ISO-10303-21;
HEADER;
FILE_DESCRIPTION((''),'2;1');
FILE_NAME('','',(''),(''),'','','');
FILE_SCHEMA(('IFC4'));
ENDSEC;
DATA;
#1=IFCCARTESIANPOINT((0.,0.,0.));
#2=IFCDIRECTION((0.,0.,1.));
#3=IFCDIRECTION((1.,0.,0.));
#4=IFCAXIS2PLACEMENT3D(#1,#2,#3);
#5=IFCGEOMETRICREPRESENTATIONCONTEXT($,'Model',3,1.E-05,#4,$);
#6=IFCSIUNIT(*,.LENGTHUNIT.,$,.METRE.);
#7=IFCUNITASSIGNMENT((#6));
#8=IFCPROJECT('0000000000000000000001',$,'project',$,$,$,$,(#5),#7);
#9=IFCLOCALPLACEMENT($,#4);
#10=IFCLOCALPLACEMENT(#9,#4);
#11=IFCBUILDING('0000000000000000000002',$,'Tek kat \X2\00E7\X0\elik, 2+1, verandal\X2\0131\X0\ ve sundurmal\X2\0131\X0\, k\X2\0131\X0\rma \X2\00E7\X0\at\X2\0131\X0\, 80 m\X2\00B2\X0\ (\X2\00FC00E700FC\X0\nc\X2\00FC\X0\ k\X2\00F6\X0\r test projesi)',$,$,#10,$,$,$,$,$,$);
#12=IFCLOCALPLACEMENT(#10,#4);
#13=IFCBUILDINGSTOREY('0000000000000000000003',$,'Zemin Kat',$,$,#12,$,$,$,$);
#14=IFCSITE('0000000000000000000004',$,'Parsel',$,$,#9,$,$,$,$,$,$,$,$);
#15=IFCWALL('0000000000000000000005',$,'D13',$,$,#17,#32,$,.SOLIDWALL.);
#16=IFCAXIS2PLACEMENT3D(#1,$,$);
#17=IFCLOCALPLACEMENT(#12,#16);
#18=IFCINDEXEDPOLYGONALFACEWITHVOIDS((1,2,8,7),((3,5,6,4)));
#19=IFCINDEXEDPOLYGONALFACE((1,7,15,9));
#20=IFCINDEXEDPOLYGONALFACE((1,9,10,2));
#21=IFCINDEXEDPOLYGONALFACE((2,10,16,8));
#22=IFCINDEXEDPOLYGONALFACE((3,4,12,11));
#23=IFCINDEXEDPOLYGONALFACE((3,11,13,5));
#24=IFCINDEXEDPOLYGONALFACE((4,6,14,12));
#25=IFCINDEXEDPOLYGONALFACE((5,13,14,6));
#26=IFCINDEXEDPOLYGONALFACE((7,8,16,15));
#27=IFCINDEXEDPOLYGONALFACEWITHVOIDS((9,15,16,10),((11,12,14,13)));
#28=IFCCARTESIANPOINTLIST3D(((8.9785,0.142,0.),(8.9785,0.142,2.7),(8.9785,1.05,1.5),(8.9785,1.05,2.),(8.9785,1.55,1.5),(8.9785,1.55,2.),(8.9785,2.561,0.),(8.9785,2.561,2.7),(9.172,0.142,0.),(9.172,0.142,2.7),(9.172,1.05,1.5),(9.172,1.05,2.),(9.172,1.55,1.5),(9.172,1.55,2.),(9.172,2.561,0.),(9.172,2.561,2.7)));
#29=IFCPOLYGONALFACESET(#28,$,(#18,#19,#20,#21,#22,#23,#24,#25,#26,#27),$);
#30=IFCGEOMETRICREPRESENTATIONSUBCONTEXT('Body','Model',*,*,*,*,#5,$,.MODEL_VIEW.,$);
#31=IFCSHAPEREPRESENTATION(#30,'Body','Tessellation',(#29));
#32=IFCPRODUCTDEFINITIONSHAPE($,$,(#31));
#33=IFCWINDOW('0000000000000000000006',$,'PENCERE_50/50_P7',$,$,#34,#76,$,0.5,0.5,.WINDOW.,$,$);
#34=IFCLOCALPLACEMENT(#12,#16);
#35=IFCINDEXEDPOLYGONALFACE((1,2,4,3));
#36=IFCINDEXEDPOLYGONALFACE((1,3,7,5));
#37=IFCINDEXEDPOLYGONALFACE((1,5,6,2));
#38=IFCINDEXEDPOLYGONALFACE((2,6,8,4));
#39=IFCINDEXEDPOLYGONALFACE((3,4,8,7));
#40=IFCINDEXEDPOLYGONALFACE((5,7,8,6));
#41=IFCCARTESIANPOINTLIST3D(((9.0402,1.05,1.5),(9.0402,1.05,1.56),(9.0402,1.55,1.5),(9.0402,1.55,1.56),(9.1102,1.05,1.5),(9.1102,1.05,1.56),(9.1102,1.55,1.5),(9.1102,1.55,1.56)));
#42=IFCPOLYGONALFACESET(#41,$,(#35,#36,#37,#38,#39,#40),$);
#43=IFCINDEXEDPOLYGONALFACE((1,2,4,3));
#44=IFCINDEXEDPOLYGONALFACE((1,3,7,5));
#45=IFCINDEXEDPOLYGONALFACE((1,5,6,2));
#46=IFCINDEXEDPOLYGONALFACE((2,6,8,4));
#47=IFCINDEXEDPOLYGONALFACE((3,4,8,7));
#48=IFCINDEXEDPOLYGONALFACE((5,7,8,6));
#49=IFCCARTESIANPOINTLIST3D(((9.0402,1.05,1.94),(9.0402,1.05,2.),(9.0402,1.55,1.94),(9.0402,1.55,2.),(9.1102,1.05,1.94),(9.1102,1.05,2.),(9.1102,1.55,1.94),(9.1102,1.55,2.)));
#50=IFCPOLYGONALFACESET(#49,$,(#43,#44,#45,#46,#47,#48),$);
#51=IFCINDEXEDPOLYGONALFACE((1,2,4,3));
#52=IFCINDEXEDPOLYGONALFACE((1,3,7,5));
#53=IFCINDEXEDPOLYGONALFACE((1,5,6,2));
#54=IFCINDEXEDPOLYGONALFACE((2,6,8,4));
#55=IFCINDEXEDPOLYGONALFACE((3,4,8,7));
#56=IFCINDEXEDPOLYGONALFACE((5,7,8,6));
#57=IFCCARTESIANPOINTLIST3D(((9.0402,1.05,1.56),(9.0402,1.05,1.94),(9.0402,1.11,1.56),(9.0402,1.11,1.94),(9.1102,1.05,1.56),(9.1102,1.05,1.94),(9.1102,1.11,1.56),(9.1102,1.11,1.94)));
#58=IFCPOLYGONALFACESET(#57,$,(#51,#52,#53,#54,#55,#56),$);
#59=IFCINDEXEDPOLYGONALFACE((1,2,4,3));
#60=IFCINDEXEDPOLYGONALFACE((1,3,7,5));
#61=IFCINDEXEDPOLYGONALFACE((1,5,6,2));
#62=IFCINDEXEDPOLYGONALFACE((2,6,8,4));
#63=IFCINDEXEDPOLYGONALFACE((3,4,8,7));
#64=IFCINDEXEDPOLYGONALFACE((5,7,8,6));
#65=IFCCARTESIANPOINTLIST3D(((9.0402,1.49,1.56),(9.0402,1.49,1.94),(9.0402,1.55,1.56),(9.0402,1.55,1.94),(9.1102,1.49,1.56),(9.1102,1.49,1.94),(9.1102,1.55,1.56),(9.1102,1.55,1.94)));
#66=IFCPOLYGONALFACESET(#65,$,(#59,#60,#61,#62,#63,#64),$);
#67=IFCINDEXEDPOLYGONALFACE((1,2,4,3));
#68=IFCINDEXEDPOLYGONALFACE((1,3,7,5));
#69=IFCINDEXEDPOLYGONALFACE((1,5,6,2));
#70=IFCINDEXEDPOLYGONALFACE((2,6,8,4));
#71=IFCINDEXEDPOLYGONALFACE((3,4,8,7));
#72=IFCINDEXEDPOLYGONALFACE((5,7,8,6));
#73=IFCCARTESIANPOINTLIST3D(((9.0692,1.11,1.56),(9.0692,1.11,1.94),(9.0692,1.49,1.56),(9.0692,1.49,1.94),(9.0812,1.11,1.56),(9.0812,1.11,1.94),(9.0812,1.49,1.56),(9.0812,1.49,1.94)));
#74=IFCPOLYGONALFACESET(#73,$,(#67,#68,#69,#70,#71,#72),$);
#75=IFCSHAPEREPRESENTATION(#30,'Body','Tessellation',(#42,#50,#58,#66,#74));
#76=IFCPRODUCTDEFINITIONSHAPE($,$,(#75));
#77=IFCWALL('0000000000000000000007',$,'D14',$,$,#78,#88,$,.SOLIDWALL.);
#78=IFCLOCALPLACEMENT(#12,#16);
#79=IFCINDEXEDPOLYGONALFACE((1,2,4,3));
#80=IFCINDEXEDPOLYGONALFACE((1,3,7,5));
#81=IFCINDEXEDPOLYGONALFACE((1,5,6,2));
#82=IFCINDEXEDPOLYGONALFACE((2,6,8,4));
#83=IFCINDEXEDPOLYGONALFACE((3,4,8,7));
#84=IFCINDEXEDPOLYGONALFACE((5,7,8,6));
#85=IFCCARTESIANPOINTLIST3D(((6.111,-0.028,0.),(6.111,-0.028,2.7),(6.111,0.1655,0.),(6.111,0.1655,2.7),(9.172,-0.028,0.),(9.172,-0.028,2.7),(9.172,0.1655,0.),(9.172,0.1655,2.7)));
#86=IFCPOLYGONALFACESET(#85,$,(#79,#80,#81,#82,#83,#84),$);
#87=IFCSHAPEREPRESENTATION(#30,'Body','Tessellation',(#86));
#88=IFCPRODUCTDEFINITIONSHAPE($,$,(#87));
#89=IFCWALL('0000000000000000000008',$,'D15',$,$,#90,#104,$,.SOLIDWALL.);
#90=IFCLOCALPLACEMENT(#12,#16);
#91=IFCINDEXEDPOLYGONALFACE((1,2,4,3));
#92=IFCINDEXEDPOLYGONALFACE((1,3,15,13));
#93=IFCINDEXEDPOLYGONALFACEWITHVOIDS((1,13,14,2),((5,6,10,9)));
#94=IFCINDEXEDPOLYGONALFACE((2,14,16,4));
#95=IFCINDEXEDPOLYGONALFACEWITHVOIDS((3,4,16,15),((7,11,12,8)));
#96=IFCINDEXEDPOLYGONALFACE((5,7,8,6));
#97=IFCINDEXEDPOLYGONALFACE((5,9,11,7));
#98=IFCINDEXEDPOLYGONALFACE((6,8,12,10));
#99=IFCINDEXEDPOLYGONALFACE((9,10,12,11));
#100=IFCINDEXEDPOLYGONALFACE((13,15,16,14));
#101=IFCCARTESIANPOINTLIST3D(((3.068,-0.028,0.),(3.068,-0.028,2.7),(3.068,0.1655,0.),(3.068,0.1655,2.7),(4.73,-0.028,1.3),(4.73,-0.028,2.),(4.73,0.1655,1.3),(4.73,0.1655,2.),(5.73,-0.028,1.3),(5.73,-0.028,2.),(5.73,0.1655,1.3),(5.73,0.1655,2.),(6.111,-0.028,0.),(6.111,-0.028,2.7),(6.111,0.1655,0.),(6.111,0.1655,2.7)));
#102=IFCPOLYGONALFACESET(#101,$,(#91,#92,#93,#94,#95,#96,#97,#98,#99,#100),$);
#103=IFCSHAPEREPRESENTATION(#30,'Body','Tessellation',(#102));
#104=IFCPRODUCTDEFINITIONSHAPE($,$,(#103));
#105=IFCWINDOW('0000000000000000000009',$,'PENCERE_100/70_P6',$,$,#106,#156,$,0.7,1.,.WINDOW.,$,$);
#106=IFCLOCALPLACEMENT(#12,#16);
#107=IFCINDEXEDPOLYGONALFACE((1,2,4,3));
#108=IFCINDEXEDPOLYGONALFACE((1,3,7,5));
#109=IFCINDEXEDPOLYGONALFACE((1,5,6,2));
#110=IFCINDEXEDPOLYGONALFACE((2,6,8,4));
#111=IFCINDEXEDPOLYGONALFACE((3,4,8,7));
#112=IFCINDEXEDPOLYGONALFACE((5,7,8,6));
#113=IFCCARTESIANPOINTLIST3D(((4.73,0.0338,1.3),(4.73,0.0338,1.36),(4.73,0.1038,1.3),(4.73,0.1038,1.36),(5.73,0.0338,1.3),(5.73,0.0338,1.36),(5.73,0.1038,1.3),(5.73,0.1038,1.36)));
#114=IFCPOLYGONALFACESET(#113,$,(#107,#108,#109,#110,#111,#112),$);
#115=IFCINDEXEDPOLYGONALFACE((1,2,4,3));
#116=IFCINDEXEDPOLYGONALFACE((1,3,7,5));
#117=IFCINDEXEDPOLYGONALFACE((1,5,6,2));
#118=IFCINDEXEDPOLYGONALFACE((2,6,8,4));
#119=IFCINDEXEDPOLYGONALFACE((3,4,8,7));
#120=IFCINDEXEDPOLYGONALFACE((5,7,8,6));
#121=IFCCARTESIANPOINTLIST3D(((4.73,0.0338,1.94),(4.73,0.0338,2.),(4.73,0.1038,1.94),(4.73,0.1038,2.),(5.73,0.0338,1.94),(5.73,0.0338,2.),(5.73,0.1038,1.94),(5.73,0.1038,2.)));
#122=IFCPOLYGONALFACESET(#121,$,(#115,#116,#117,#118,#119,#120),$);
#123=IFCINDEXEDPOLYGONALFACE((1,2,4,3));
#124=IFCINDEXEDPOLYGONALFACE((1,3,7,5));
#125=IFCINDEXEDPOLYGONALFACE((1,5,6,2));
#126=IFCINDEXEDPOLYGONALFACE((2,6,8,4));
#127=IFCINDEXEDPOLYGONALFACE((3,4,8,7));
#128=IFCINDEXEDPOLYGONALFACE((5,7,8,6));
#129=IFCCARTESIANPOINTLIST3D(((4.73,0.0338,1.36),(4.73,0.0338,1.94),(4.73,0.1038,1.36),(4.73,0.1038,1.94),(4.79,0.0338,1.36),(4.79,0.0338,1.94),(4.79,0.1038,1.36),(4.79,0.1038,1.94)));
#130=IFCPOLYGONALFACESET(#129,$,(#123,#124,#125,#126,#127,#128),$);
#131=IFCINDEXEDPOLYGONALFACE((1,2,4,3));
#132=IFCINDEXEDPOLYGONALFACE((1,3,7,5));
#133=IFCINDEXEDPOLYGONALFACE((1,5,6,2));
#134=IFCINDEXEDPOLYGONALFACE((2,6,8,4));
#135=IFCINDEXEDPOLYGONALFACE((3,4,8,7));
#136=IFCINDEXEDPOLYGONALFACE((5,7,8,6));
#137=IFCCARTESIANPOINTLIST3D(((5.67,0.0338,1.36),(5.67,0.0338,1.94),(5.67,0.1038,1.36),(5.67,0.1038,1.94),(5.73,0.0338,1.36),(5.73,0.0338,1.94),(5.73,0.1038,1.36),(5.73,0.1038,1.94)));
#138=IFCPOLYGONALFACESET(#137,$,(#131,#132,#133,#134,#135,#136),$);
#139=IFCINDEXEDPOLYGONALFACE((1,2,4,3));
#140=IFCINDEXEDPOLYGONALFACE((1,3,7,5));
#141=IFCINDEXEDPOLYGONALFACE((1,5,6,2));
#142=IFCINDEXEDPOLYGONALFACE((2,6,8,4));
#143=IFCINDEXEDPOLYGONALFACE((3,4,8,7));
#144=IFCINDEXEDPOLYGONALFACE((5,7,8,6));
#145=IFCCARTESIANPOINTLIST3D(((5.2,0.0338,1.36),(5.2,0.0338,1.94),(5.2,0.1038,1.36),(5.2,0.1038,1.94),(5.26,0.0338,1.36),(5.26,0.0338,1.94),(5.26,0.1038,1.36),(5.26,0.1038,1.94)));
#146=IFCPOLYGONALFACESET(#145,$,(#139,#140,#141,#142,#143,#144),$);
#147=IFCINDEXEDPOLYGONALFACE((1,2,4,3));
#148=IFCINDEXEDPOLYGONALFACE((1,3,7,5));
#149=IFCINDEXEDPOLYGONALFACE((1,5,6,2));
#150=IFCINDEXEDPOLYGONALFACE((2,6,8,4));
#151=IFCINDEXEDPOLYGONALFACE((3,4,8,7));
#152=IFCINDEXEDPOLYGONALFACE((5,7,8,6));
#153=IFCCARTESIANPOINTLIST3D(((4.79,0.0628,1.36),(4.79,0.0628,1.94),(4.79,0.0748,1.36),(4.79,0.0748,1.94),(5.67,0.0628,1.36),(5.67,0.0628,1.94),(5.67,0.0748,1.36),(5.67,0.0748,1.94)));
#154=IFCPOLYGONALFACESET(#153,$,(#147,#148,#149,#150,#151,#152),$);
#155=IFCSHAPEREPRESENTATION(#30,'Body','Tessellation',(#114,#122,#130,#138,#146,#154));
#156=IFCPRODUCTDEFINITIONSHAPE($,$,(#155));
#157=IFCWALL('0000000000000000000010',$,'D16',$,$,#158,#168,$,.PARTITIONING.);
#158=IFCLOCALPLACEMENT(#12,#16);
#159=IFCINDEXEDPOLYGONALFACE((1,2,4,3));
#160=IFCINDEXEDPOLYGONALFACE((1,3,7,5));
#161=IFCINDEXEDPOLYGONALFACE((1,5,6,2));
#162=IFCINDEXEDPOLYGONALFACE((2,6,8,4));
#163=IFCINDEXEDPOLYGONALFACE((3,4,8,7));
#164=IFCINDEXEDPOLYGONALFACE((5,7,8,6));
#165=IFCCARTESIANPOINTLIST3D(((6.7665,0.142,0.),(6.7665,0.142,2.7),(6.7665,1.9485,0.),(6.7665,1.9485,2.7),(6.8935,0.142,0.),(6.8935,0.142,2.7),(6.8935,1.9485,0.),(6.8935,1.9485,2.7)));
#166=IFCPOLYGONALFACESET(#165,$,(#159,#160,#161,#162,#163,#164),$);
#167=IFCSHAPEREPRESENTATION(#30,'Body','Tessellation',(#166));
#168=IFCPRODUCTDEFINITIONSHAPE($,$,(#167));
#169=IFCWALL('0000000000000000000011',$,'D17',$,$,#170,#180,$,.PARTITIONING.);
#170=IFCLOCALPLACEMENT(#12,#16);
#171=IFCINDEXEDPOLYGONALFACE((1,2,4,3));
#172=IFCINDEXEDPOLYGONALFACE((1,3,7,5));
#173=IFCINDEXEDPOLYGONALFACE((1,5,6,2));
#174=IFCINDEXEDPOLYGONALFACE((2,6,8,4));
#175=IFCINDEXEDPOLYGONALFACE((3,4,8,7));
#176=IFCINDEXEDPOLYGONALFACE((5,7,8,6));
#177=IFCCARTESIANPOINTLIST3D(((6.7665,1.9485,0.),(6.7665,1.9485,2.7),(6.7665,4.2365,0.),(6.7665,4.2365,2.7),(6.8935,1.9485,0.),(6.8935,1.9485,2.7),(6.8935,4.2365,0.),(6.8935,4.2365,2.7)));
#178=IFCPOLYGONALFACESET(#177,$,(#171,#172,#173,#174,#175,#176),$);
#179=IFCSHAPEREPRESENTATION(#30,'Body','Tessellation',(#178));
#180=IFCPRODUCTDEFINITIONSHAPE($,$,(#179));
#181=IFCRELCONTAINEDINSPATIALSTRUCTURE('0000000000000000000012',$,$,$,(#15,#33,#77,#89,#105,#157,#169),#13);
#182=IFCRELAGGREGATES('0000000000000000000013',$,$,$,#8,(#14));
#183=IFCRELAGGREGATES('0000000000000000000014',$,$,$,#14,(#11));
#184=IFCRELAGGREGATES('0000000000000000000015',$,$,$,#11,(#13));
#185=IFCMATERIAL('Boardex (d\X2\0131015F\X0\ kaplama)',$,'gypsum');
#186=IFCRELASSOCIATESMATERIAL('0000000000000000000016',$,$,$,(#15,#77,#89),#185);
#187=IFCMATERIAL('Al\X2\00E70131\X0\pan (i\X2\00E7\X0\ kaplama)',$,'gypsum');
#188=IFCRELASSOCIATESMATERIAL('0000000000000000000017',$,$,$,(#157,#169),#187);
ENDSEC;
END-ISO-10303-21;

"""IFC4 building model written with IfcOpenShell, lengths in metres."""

from ifc_helpers import new_model, si_unit, frame, origin_with_axes, place, context, subcontext, project, spatial, line, indexed_curve, outline, extrude, material, element, fill, save


model = new_model("IFC4")

# Units and contexts
model_context = context("Model", 3, precision=1e-05, world=origin_with_axes())
body_context = subcontext(model_context, "Body", "Model", "MODEL_VIEW")
ifc_project = project(units=[si_unit("LENGTHUNIT", "METRE")], contexts=[model_context])

# Site, building, storey
site_placement = place(None, origin_with_axes())
site = spatial("IfcSite", under=ifc_project, at=site_placement, Name="Parsel")
building_placement = place(site_placement, origin_with_axes())
building = spatial("IfcBuilding", under=site, at=building_placement, Name="Tek kat çelik, 2+1, verandalı ve sundurmalı, kırma çatı, 80 m² (üçüncü kör test projesi)")
storey_placement = place(building_placement, origin_with_axes())
storey = spatial("IfcBuildingStorey", under=building, at=storey_placement, Name="Zemin Kat")

# Shared definitions
ifc_material_1 = material(Name="Boardex (dış kaplama)", Category="gypsum")

# Wall, opening, window
wall_1_placement = place(storey_placement, origin_with_axes())
wall_1 = element("IfcWall", 1, at=wall_1_placement, inside=storey, material=ifc_material_1, Name="D13", PredefinedType="SOLIDWALL", context=body_context, shape_type="SweptSolid", body=[
    extrude(outline(indexed_curve([(0.0, 0.0), (0.1935, 0.0), (0.1935, 2.419), (0.0, 2.419)], segments=[line(1, 2, 3, 4, 1)])), frame((8.9785, 0.142, 0.0), z_axis=(0.0, 0.0, 1.0), x_axis=(1.0, 0.0, 0.0)), (0.0, 0.0, 1.0), 2.7),
])
opening_1_placement = place(wall_1_placement, origin_with_axes())
opening_1 = element("IfcOpeningElement", 2, at=opening_1_placement, cuts=wall_1, PredefinedType="OPENING", context=body_context, shape_type="SweptSolid", body=[
    extrude(outline(indexed_curve([(0.0, 0.0), (0.2335, 0.0), (0.2335, 0.5), (0.0, 0.5)], segments=[line(1, 2, 3, 4, 1)])), frame((8.9585, 1.05, 1.5), z_axis=(0.0, 0.0, 1.0), x_axis=(1.0, 0.0, 0.0)), (0.0, 0.0, 1.0), 0.5),
])
window_1_placement = place(storey_placement, origin_with_axes())
window_1 = element("IfcWindow", 3, at=window_1_placement, inside=storey, Name="PENCERE_50/50_P7", OverallHeight=0.5, OverallWidth=0.5, PredefinedType="WINDOW", context=body_context, shape_type="SweptSolid", body=[
    extrude(outline(indexed_curve([(0.0, 0.0), (0.07, 0.0), (0.07, 0.5), (0.0, 0.5)], segments=[line(1, 2, 3, 4, 1)])), frame((9.0403, 1.05, 1.5), z_axis=(0.0, 0.0, 1.0), x_axis=(1.0, 0.0, 0.0)), (0.0, 0.0, 1.0), 0.06),
    extrude(outline(indexed_curve([(0.0, 0.0), (0.07, 0.0), (0.07, 0.5), (0.0, 0.5)], segments=[line(1, 2, 3, 4, 1)])), frame((9.0403, 1.05, 1.94), z_axis=(0.0, 0.0, 1.0), x_axis=(1.0, 0.0, 0.0)), (0.0, 0.0, 1.0), 0.06),
    extrude(outline(indexed_curve([(0.0, 0.0), (0.07, 0.0), (0.07, 0.06), (0.0, 0.06)], segments=[line(1, 2, 3, 4, 1)])), frame((9.0403, 1.05, 1.56), z_axis=(0.0, 0.0, 1.0), x_axis=(1.0, 0.0, 0.0)), (0.0, 0.0, 1.0), 0.38),
    extrude(outline(indexed_curve([(0.0, 0.0), (0.07, 0.0), (0.07, 0.06), (0.0, 0.06)], segments=[line(1, 2, 3, 4, 1)])), frame((9.0403, 1.49, 1.56), z_axis=(0.0, 0.0, 1.0), x_axis=(1.0, 0.0, 0.0)), (0.0, 0.0, 1.0), 0.38),
    extrude(outline(indexed_curve([(0.0, 0.0), (0.012, 0.0), (0.012, 0.38), (0.0, 0.38)], segments=[line(1, 2, 3, 4, 1)])), frame((9.0693, 1.11, 1.56), z_axis=(0.0, 0.0, 1.0), x_axis=(1.0, 0.0, 0.0)), (0.0, 0.0, 1.0), 0.38),
])
fill(opening_1, window_1)

# Wall
wall_2_placement = place(storey_placement, origin_with_axes())
element("IfcWall", 4, at=wall_2_placement, inside=storey, material=ifc_material_1, Name="D14", PredefinedType="SOLIDWALL", context=body_context, shape_type="SweptSolid", body=[
    extrude(outline(indexed_curve([(0.0, 0.0), (3.061, 0.0), (3.061, 0.1935), (0.0, 0.1935)], segments=[line(1, 2, 3, 4, 1)])), frame((6.111, -0.028, 0.0), z_axis=(0.0, 0.0, 1.0), x_axis=(1.0, 0.0, 0.0)), (0.0, 0.0, 1.0), 2.7),
])

# Wall, opening, window
wall_3_placement = place(storey_placement, origin_with_axes())
wall_3 = element("IfcWall", 5, at=wall_3_placement, inside=storey, material=ifc_material_1, Name="D15", PredefinedType="SOLIDWALL", context=body_context, shape_type="SweptSolid", body=[
    extrude(outline(indexed_curve([(0.0, 0.0), (3.043, 0.0), (3.043, 0.1935), (0.0, 0.1935)], segments=[line(1, 2, 3, 4, 1)])), frame((3.068, -0.028, 0.0), z_axis=(0.0, 0.0, 1.0), x_axis=(1.0, 0.0, 0.0)), (0.0, 0.0, 1.0), 2.7),
])
opening_2_placement = place(wall_3_placement, origin_with_axes())
opening_2 = element("IfcOpeningElement", 6, at=opening_2_placement, cuts=wall_3, PredefinedType="OPENING", context=body_context, shape_type="SweptSolid", body=[
    extrude(outline(indexed_curve([(0.0, 0.0), (1.0, 0.0), (1.0, 0.2335), (0.0, 0.2335)], segments=[line(1, 2, 3, 4, 1)])), frame((4.73, -0.048, 1.3), z_axis=(0.0, 0.0, 1.0), x_axis=(1.0, 0.0, 0.0)), (0.0, 0.0, 1.0), 0.7),
])
window_2_placement = place(storey_placement, origin_with_axes())
window_2 = element("IfcWindow", 7, at=window_2_placement, inside=storey, Name="PENCERE_100/70_P6", OverallHeight=0.7, OverallWidth=1.0, PredefinedType="WINDOW", context=body_context, shape_type="SweptSolid", body=[
    extrude(outline(indexed_curve([(0.0, 0.0), (1.0, 0.0), (1.0, 0.07), (0.0, 0.07)], segments=[line(1, 2, 3, 4, 1)])), frame((4.73, 0.0338, 1.3), z_axis=(0.0, 0.0, 1.0), x_axis=(1.0, 0.0, 0.0)), (0.0, 0.0, 1.0), 0.06),
    extrude(outline(indexed_curve([(0.0, 0.0), (1.0, 0.0), (1.0, 0.07), (0.0, 0.07)], segments=[line(1, 2, 3, 4, 1)])), frame((4.73, 0.0338, 1.94), z_axis=(0.0, 0.0, 1.0), x_axis=(1.0, 0.0, 0.0)), (0.0, 0.0, 1.0), 0.06),
    extrude(outline(indexed_curve([(0.0, 0.0), (0.06, 0.0), (0.06, 0.07), (0.0, 0.07)], segments=[line(1, 2, 3, 4, 1)])), frame((4.73, 0.0338, 1.36), z_axis=(0.0, 0.0, 1.0), x_axis=(1.0, 0.0, 0.0)), (0.0, 0.0, 1.0), 0.58),
    extrude(outline(indexed_curve([(0.0, 0.0), (0.06, 0.0), (0.06, 0.07), (0.0, 0.07)], segments=[line(1, 2, 3, 4, 1)])), frame((5.67, 0.0338, 1.36), z_axis=(0.0, 0.0, 1.0), x_axis=(1.0, 0.0, 0.0)), (0.0, 0.0, 1.0), 0.58),
    extrude(outline(indexed_curve([(0.0, 0.0), (0.06, 0.0), (0.06, 0.07), (0.0, 0.07)], segments=[line(1, 2, 3, 4, 1)])), frame((5.2, 0.0338, 1.36), z_axis=(0.0, 0.0, 1.0), x_axis=(1.0, 0.0, 0.0)), (0.0, 0.0, 1.0), 0.58),
    extrude(outline(indexed_curve([(0.0, 0.0), (0.88, 0.0), (0.88, 0.012), (0.0, 0.012)], segments=[line(1, 2, 3, 4, 1)])), frame((4.79, 0.0628, 1.36), z_axis=(0.0, 0.0, 1.0), x_axis=(1.0, 0.0, 0.0)), (0.0, 0.0, 1.0), 0.58),
])
fill(opening_2, window_2)

# Walls
ifc_material_2 = material(Name="Alçıpan (iç kaplama)", Category="gypsum")
wall_4_placement = place(storey_placement, origin_with_axes())
element("IfcWall", 8, at=wall_4_placement, inside=storey, material=ifc_material_2, Name="D16", PredefinedType="PARTITIONING", context=body_context, shape_type="SweptSolid", body=[
    extrude(outline(indexed_curve([(0.0, 0.0), (0.127, 0.0), (0.127, 1.8065), (0.0, 1.8065)], segments=[line(1, 2, 3, 4, 1)])), frame((6.7665, 0.142, 0.0), z_axis=(0.0, 0.0, 1.0), x_axis=(1.0, 0.0, 0.0)), (0.0, 0.0, 1.0), 2.7),
])
wall_5_placement = place(storey_placement, origin_with_axes())
element("IfcWall", 9, at=wall_5_placement, inside=storey, material=ifc_material_2, Name="D17", PredefinedType="PARTITIONING", context=body_context, shape_type="SweptSolid", body=[
    extrude(outline(indexed_curve([(0.0, 0.0), (0.127, 0.0), (0.127, 2.288), (0.0, 2.288)], segments=[line(1, 2, 3, 4, 1)])), frame((6.7665, 1.9485, 0.0), z_axis=(0.0, 0.0, 1.0), x_axis=(1.0, 0.0, 0.0)), (0.0, 0.0, 1.0), 2.7),
])

save(model, "model.ifc")
